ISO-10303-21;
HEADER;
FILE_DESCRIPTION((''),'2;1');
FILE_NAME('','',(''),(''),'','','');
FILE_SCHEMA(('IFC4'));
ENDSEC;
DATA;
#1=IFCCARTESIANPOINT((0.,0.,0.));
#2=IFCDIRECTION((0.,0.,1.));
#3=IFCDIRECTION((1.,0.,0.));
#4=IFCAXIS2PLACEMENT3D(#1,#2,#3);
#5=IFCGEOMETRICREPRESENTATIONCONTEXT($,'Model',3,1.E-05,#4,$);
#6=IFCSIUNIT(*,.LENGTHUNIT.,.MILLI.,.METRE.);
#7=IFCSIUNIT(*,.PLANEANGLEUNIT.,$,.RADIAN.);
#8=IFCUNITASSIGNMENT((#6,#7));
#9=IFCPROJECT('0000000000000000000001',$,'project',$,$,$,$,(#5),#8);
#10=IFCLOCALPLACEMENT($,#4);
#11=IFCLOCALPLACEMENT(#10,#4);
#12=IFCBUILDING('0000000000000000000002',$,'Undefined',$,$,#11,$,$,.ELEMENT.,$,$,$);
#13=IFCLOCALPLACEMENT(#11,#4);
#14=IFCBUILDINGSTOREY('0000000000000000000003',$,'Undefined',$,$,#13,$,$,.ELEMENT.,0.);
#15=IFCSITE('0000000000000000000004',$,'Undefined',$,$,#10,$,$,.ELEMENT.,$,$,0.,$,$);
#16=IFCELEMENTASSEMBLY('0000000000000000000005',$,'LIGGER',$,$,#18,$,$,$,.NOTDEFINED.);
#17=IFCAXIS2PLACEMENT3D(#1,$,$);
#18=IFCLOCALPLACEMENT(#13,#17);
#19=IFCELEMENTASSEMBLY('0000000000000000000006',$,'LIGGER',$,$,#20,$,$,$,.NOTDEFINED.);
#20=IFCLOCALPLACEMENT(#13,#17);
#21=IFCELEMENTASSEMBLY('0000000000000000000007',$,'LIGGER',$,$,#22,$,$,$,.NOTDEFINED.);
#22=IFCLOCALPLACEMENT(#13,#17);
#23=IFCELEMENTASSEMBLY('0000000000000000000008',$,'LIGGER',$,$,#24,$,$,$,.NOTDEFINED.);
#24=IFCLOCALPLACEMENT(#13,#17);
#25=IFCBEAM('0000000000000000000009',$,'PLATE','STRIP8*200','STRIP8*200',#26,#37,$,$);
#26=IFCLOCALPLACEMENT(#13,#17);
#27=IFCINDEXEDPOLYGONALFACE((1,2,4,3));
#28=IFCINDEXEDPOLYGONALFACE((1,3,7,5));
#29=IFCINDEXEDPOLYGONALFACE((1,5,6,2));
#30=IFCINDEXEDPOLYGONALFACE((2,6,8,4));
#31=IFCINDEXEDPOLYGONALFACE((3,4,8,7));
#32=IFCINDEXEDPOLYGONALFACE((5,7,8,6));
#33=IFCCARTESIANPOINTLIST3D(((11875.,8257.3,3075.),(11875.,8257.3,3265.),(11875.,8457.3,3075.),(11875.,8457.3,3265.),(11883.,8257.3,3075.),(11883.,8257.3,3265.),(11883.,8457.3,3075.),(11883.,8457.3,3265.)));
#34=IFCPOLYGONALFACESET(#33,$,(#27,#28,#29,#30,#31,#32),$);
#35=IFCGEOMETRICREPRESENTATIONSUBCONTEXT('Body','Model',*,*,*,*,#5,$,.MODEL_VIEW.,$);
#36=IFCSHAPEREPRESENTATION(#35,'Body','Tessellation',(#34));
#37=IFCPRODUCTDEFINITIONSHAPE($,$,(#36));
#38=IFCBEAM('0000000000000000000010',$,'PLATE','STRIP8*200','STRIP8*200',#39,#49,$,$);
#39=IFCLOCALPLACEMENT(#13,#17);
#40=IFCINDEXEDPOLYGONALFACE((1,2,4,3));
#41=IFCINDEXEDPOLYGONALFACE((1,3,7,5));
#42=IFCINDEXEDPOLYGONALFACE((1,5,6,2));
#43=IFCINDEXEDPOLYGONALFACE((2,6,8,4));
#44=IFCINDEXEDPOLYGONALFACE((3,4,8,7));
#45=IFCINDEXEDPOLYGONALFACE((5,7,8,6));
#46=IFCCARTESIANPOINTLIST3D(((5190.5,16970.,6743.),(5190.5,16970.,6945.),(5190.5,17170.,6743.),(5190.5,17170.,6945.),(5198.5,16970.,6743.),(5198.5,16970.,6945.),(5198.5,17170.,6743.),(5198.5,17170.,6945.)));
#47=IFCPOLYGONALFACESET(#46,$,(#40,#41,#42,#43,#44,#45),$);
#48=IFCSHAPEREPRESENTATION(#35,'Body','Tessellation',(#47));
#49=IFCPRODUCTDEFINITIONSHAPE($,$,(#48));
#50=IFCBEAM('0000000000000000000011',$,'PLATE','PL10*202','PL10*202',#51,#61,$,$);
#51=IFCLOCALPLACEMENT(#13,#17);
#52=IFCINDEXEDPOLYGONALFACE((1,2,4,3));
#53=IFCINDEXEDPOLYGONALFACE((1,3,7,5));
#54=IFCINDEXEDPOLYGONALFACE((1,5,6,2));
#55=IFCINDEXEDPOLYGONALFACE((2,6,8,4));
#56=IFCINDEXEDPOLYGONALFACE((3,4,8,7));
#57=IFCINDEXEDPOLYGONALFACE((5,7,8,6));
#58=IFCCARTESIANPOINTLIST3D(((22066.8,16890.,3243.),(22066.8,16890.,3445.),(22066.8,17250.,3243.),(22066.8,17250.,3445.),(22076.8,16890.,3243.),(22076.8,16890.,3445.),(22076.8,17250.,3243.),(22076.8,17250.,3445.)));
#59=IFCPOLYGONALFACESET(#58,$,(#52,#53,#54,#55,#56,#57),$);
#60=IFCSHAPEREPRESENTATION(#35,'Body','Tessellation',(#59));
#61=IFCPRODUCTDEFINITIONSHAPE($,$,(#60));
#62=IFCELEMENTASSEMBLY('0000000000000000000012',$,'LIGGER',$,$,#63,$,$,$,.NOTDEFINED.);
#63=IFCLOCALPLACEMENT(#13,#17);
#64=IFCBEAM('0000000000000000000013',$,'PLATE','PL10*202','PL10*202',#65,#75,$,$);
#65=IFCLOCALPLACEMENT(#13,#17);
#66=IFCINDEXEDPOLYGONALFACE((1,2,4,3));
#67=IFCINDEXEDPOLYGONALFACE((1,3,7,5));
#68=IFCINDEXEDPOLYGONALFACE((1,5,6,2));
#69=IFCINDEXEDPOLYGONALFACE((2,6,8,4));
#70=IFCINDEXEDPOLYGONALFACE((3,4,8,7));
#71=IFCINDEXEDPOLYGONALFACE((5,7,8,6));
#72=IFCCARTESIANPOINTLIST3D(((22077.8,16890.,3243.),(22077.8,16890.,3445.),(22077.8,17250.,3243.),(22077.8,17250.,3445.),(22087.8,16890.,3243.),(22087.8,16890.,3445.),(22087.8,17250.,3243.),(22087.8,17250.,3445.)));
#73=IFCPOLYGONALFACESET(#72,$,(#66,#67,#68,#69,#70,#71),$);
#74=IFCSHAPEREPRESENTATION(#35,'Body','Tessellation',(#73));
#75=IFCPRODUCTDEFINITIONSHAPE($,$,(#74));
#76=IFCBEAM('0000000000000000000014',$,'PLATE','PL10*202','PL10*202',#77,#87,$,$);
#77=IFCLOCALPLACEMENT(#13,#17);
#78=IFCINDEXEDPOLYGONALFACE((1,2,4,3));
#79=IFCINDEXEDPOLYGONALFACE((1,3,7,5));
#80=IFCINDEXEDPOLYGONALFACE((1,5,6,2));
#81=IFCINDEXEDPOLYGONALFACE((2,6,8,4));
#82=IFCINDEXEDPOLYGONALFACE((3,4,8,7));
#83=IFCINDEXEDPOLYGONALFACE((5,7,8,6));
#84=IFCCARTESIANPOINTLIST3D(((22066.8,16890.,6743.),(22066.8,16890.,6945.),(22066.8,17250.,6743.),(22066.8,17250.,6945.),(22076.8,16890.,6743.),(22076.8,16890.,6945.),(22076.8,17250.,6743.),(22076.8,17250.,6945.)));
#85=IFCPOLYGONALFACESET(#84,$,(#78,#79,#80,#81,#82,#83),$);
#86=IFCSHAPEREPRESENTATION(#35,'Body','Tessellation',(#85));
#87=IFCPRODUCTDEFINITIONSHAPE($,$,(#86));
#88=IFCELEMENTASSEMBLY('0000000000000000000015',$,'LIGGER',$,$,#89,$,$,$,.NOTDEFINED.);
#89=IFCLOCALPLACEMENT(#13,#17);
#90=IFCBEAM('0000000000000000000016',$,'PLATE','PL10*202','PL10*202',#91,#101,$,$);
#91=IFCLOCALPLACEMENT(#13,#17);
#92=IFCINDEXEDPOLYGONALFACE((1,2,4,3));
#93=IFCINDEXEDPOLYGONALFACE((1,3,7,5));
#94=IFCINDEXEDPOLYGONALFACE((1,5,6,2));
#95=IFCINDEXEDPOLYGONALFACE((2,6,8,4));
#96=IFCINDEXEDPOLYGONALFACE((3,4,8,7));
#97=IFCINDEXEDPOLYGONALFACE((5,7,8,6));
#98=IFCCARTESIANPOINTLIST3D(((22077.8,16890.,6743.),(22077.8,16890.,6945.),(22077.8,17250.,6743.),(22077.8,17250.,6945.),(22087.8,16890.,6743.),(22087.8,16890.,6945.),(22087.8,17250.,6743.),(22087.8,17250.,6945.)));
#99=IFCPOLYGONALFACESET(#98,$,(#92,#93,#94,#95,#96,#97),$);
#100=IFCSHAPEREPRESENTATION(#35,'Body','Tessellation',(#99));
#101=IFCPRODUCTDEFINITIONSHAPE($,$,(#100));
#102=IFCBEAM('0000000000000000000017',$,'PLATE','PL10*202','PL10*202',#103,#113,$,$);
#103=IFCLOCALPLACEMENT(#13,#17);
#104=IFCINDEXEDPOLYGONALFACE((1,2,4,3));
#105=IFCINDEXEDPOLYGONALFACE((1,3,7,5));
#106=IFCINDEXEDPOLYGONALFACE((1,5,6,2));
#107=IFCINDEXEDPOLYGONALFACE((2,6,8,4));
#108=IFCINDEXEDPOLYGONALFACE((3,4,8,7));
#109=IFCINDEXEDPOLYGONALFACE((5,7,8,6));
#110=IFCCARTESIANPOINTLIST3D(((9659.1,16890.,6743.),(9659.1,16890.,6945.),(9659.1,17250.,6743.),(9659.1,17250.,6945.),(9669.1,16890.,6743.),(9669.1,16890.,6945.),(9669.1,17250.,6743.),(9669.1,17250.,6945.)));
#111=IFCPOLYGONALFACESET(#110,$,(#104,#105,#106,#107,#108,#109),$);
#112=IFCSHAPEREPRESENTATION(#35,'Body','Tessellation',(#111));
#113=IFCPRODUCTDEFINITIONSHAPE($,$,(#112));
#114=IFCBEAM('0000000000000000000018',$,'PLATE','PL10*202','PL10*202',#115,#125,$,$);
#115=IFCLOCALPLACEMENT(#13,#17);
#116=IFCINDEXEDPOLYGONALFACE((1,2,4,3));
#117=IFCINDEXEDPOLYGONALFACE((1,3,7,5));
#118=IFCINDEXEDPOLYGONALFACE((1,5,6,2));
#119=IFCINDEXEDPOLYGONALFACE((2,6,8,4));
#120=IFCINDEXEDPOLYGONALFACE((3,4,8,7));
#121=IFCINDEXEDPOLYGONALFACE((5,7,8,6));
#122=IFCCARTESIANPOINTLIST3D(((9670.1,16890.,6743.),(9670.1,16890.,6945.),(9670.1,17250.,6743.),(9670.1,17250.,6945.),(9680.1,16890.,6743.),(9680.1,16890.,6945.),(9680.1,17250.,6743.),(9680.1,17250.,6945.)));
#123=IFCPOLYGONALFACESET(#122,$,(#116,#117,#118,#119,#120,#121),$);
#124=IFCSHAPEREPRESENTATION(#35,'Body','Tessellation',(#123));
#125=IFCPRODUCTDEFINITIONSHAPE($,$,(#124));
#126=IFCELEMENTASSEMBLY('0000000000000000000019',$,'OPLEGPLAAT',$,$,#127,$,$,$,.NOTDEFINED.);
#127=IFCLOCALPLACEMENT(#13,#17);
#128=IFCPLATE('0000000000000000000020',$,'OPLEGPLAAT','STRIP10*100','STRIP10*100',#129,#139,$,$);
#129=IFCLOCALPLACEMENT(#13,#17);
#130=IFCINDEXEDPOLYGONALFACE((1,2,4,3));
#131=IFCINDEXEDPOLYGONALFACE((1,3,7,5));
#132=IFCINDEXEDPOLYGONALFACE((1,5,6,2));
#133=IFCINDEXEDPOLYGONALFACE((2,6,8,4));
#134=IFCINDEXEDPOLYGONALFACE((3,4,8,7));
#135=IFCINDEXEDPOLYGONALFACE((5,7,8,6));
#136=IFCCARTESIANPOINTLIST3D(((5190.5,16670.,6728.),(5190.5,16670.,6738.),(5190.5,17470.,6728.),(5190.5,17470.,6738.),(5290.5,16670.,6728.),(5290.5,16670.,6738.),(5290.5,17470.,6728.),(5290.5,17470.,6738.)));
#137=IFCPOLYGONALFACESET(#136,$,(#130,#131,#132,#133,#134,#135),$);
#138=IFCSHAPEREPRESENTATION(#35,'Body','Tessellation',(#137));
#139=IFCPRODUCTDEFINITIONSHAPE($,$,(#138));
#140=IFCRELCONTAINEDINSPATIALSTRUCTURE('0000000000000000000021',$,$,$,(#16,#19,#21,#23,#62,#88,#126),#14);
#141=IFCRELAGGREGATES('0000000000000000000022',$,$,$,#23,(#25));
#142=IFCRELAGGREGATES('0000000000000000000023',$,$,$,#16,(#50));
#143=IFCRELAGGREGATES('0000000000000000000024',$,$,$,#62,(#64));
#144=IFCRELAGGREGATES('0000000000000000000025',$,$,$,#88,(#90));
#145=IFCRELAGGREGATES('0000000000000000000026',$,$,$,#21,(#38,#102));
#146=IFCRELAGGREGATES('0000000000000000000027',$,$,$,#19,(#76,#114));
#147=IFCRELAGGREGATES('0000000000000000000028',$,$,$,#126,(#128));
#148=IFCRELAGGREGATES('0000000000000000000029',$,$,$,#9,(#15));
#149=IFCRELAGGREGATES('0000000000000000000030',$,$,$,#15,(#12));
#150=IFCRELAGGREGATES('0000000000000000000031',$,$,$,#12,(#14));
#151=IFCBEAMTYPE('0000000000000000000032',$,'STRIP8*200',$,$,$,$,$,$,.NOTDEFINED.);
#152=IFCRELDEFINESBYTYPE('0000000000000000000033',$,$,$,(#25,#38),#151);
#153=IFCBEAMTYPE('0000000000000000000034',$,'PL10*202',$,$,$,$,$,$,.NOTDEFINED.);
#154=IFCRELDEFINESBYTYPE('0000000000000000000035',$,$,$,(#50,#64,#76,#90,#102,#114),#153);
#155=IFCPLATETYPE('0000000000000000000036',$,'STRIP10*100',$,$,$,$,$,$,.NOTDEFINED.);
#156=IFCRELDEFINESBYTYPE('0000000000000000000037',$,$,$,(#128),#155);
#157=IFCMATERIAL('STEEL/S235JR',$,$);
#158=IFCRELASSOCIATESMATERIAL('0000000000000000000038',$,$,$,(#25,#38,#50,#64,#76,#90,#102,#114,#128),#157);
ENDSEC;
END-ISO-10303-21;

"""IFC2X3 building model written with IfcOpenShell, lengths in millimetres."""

from ifc_helpers import new_model, si_unit, frame, origin_with_axes, origin_2d_with_axis, place, context, subcontext, project, spatial, rectangle, extrude, material, type_object, element, aggregate, save


model = new_model("IFC2X3")

# Units and contexts
model_context = context("Model", 3, precision=1e-05, world=origin_with_axes())
body_context = subcontext(model_context, "Body", "Model", "MODEL_VIEW")
ifc_project = project(units=[si_unit("LENGTHUNIT", "METRE", prefix="MILLI"), si_unit("PLANEANGLEUNIT", "RADIAN")], contexts=[model_context])

# Site, building, storey
site_placement = place(None, origin_with_axes())
site = spatial("IfcSite", under=ifc_project, at=site_placement, Name="Undefined", CompositionType="ELEMENT", RefElevation=0.0)
building_placement = place(site_placement, origin_with_axes())
building = spatial("IfcBuilding", under=site, at=building_placement, Name="Undefined", CompositionType="ELEMENT")
storey_placement = place(building_placement, origin_with_axes())
storey = spatial("IfcBuildingStorey", under=building, at=storey_placement, Name="Undefined", CompositionType="ELEMENT", Elevation=0.0)

# Shared definitions
ifc_material = material(Name="STEEL/S235JR")

# Element assemblies
assembly_1_placement = place(storey_placement, origin_with_axes())
assembly_1 = element("IfcElementAssembly", 1, at=assembly_1_placement, inside=storey, Name="LIGGER", PredefinedType="NOTDEFINED")
assembly_2_placement = place(storey_placement, origin_with_axes())
assembly_2 = element("IfcElementAssembly", 2, at=assembly_2_placement, inside=storey, Name="LIGGER", PredefinedType="NOTDEFINED")
assembly_3_placement = place(storey_placement, origin_with_axes())
assembly_3 = element("IfcElementAssembly", 3, at=assembly_3_placement, inside=storey, Name="LIGGER", PredefinedType="NOTDEFINED")
assembly_4_placement = place(storey_placement, origin_with_axes())
assembly_4 = element("IfcElementAssembly", 4, at=assembly_4_placement, inside=storey, Name="LIGGER", PredefinedType="NOTDEFINED")

# Beams
beam_type_1 = type_object("IfcBeamType", Name="STRIP8*200", PredefinedType="NOTDEFINED")
beam_1_placement = place(assembly_4_placement, frame((11879.0, 8357.3, 3075.0), z_axis=(0.0, -1.0, 0.0), x_axis=(0.0, 0.0, 1.0)))
beam_1 = element("IfcBeam", 5, at=beam_1_placement, type_object=beam_type_1, material=ifc_material, Name="PLATE", Description="STRIP8*200", ObjectType="STRIP8*200", context=body_context, shape_type="SweptSolid", body=[
    extrude(rectangle(XDim=8.0, YDim=200.0, at=origin_2d_with_axis()), frame((190.0, 0.0, 0.0), z_axis=(-1.0, 0.0, 0.0), x_axis=(0.0, -1.0, 0.0)), (0.0, 0.0, 1.0), 190.0),
])
aggregate(assembly_4, [beam_1])
beam_2_placement = place(assembly_3_placement, frame((5194.5, 17070.0, 6743.0), z_axis=(0.0, -1.0, 0.0), x_axis=(0.0, 0.0, 1.0)))
beam_2 = element("IfcBeam", 6, at=beam_2_placement, type_object=beam_type_1, material=ifc_material, Name="PLATE", Description="STRIP8*200", ObjectType="STRIP8*200", context=body_context, shape_type="SweptSolid", body=[
    extrude(rectangle(XDim=8.0, YDim=200.0, at=origin_2d_with_axis()), frame((202.0, 0.0, 0.0), z_axis=(-1.0, 0.0, 0.0), x_axis=(0.0, -1.0, 0.0)), (0.0, 0.0, 1.0), 202.0),
])
beam_type_2 = type_object("IfcBeamType", Name="PL10*202", PredefinedType="NOTDEFINED")
beam_3_placement = place(assembly_1_placement, frame((22071.8, 17070.0, 3243.0), z_axis=(0.0, -1.0, 0.0), x_axis=(0.0, 0.0, 1.0)))
beam_3 = element("IfcBeam", 7, at=beam_3_placement, type_object=beam_type_2, material=ifc_material, Name="PLATE", Description="PL10*202", ObjectType="PL10*202", context=body_context, shape_type="SweptSolid", body=[
    extrude(rectangle(XDim=10.0, YDim=360.0, at=origin_2d_with_axis()), frame((202.0, 0.0, 0.0), z_axis=(-1.0, 0.0, 0.0), x_axis=(0.0, -1.0, 0.0)), (0.0, 0.0, 1.0), 202.0),
])
aggregate(assembly_1, [beam_3])

# Element assembly, beam
assembly_5_placement = place(storey_placement, origin_with_axes())
assembly_5 = element("IfcElementAssembly", 8, at=assembly_5_placement, inside=storey, Name="LIGGER", PredefinedType="NOTDEFINED")
beam_4_placement = place(assembly_5_placement, frame((22082.8, 17070.0, 3243.0), z_axis=(0.0, -1.0, 0.0), x_axis=(0.0, 0.0, 1.0)))
beam_4 = element("IfcBeam", 9, at=beam_4_placement, type_object=beam_type_2, material=ifc_material, Name="PLATE", Description="PL10*202", ObjectType="PL10*202", context=body_context, shape_type="SweptSolid", body=[
    extrude(rectangle(XDim=10.0, YDim=360.0, at=origin_2d_with_axis()), frame((202.0, 0.0, 0.0), z_axis=(-1.0, 0.0, 0.0), x_axis=(0.0, -1.0, 0.0)), (0.0, 0.0, 1.0), 202.0),
])
aggregate(assembly_5, [beam_4])

# Beam
beam_5_placement = place(assembly_2_placement, frame((22071.8, 17070.0, 6743.0), z_axis=(0.0, -1.0, 0.0), x_axis=(0.0, 0.0, 1.0)))
beam_5 = element("IfcBeam", 10, at=beam_5_placement, type_object=beam_type_2, material=ifc_material, Name="PLATE", Description="PL10*202", ObjectType="PL10*202", context=body_context, shape_type="SweptSolid", body=[
    extrude(rectangle(XDim=10.0, YDim=360.0, at=origin_2d_with_axis()), frame((202.0, 0.0, 0.0), z_axis=(-1.0, 0.0, 0.0), x_axis=(0.0, -1.0, 0.0)), (0.0, 0.0, 1.0), 202.0),
])

# Element assembly, beam
assembly_6_placement = place(storey_placement, origin_with_axes())
assembly_6 = element("IfcElementAssembly", 11, at=assembly_6_placement, inside=storey, Name="LIGGER", PredefinedType="NOTDEFINED")
beam_6_placement = place(assembly_6_placement, frame((22082.8, 17070.0, 6743.0), z_axis=(0.0, -1.0, 0.0), x_axis=(0.0, 0.0, 1.0)))
beam_6 = element("IfcBeam", 12, at=beam_6_placement, type_object=beam_type_2, material=ifc_material, Name="PLATE", Description="PL10*202", ObjectType="PL10*202", context=body_context, shape_type="SweptSolid", body=[
    extrude(rectangle(XDim=10.0, YDim=360.0, at=origin_2d_with_axis()), frame((202.0, 0.0, 0.0), z_axis=(-1.0, 0.0, 0.0), x_axis=(0.0, -1.0, 0.0)), (0.0, 0.0, 1.0), 202.0),
])
aggregate(assembly_6, [beam_6])

# Beams
beam_7_placement = place(assembly_3_placement, frame((9664.1, 17070.0, 6743.0), z_axis=(0.0, -1.0, 0.0), x_axis=(0.0, 0.0, 1.0)))
beam_7 = element("IfcBeam", 13, at=beam_7_placement, type_object=beam_type_2, material=ifc_material, Name="PLATE", Description="PL10*202", ObjectType="PL10*202", context=body_context, shape_type="SweptSolid", body=[
    extrude(rectangle(XDim=10.0, YDim=360.0, at=origin_2d_with_axis()), frame((202.0, 0.0, 0.0), z_axis=(-1.0, 0.0, 0.0), x_axis=(0.0, -1.0, 0.0)), (0.0, 0.0, 1.0), 202.0),
])
aggregate(assembly_3, [beam_2, beam_7])
beam_8_placement = place(assembly_2_placement, frame((9675.1, 17070.0, 6743.0), z_axis=(0.0, -1.0, 0.0), x_axis=(0.0, 0.0, 1.0)))
beam_8 = element("IfcBeam", 14, at=beam_8_placement, type_object=beam_type_2, material=ifc_material, Name="PLATE", Description="PL10*202", ObjectType="PL10*202", context=body_context, shape_type="SweptSolid", body=[
    extrude(rectangle(XDim=10.0, YDim=360.0, at=origin_2d_with_axis()), frame((202.0, 0.0, 0.0), z_axis=(-1.0, 0.0, 0.0), x_axis=(0.0, -1.0, 0.0)), (0.0, 0.0, 1.0), 202.0),
])
aggregate(assembly_2, [beam_5, beam_8])

# Element assembly, plate
assembly_7_placement = place(storey_placement, origin_with_axes())
assembly_7 = element("IfcElementAssembly", 15, at=assembly_7_placement, inside=storey, Name="OPLEGPLAAT", PredefinedType="NOTDEFINED")
plate_type = type_object("IfcPlateType", Name="STRIP10*100", PredefinedType="NOTDEFINED")
plate_placement = place(assembly_7_placement, frame((5240.5, 16670.0, 6733.0), z_axis=(-1.0, 0.0, 0.0), x_axis=(0.0, 1.0, 0.0)))
plate = element("IfcPlate", 16, at=plate_placement, type_object=plate_type, material=ifc_material, Name="OPLEGPLAAT", Description="STRIP10*100", ObjectType="STRIP10*100", context=body_context, shape_type="SweptSolid", body=[
    extrude(rectangle(XDim=10.0, YDim=100.0, at=origin_2d_with_axis()), frame((800.0, 0.0, 0.0), z_axis=(-1.0, 0.0, 0.0), x_axis=(0.0, -1.0, 0.0)), (0.0, 0.0, 1.0), 800.0),
])
aggregate(assembly_7, [plate])

save(model, "model.ifc")
